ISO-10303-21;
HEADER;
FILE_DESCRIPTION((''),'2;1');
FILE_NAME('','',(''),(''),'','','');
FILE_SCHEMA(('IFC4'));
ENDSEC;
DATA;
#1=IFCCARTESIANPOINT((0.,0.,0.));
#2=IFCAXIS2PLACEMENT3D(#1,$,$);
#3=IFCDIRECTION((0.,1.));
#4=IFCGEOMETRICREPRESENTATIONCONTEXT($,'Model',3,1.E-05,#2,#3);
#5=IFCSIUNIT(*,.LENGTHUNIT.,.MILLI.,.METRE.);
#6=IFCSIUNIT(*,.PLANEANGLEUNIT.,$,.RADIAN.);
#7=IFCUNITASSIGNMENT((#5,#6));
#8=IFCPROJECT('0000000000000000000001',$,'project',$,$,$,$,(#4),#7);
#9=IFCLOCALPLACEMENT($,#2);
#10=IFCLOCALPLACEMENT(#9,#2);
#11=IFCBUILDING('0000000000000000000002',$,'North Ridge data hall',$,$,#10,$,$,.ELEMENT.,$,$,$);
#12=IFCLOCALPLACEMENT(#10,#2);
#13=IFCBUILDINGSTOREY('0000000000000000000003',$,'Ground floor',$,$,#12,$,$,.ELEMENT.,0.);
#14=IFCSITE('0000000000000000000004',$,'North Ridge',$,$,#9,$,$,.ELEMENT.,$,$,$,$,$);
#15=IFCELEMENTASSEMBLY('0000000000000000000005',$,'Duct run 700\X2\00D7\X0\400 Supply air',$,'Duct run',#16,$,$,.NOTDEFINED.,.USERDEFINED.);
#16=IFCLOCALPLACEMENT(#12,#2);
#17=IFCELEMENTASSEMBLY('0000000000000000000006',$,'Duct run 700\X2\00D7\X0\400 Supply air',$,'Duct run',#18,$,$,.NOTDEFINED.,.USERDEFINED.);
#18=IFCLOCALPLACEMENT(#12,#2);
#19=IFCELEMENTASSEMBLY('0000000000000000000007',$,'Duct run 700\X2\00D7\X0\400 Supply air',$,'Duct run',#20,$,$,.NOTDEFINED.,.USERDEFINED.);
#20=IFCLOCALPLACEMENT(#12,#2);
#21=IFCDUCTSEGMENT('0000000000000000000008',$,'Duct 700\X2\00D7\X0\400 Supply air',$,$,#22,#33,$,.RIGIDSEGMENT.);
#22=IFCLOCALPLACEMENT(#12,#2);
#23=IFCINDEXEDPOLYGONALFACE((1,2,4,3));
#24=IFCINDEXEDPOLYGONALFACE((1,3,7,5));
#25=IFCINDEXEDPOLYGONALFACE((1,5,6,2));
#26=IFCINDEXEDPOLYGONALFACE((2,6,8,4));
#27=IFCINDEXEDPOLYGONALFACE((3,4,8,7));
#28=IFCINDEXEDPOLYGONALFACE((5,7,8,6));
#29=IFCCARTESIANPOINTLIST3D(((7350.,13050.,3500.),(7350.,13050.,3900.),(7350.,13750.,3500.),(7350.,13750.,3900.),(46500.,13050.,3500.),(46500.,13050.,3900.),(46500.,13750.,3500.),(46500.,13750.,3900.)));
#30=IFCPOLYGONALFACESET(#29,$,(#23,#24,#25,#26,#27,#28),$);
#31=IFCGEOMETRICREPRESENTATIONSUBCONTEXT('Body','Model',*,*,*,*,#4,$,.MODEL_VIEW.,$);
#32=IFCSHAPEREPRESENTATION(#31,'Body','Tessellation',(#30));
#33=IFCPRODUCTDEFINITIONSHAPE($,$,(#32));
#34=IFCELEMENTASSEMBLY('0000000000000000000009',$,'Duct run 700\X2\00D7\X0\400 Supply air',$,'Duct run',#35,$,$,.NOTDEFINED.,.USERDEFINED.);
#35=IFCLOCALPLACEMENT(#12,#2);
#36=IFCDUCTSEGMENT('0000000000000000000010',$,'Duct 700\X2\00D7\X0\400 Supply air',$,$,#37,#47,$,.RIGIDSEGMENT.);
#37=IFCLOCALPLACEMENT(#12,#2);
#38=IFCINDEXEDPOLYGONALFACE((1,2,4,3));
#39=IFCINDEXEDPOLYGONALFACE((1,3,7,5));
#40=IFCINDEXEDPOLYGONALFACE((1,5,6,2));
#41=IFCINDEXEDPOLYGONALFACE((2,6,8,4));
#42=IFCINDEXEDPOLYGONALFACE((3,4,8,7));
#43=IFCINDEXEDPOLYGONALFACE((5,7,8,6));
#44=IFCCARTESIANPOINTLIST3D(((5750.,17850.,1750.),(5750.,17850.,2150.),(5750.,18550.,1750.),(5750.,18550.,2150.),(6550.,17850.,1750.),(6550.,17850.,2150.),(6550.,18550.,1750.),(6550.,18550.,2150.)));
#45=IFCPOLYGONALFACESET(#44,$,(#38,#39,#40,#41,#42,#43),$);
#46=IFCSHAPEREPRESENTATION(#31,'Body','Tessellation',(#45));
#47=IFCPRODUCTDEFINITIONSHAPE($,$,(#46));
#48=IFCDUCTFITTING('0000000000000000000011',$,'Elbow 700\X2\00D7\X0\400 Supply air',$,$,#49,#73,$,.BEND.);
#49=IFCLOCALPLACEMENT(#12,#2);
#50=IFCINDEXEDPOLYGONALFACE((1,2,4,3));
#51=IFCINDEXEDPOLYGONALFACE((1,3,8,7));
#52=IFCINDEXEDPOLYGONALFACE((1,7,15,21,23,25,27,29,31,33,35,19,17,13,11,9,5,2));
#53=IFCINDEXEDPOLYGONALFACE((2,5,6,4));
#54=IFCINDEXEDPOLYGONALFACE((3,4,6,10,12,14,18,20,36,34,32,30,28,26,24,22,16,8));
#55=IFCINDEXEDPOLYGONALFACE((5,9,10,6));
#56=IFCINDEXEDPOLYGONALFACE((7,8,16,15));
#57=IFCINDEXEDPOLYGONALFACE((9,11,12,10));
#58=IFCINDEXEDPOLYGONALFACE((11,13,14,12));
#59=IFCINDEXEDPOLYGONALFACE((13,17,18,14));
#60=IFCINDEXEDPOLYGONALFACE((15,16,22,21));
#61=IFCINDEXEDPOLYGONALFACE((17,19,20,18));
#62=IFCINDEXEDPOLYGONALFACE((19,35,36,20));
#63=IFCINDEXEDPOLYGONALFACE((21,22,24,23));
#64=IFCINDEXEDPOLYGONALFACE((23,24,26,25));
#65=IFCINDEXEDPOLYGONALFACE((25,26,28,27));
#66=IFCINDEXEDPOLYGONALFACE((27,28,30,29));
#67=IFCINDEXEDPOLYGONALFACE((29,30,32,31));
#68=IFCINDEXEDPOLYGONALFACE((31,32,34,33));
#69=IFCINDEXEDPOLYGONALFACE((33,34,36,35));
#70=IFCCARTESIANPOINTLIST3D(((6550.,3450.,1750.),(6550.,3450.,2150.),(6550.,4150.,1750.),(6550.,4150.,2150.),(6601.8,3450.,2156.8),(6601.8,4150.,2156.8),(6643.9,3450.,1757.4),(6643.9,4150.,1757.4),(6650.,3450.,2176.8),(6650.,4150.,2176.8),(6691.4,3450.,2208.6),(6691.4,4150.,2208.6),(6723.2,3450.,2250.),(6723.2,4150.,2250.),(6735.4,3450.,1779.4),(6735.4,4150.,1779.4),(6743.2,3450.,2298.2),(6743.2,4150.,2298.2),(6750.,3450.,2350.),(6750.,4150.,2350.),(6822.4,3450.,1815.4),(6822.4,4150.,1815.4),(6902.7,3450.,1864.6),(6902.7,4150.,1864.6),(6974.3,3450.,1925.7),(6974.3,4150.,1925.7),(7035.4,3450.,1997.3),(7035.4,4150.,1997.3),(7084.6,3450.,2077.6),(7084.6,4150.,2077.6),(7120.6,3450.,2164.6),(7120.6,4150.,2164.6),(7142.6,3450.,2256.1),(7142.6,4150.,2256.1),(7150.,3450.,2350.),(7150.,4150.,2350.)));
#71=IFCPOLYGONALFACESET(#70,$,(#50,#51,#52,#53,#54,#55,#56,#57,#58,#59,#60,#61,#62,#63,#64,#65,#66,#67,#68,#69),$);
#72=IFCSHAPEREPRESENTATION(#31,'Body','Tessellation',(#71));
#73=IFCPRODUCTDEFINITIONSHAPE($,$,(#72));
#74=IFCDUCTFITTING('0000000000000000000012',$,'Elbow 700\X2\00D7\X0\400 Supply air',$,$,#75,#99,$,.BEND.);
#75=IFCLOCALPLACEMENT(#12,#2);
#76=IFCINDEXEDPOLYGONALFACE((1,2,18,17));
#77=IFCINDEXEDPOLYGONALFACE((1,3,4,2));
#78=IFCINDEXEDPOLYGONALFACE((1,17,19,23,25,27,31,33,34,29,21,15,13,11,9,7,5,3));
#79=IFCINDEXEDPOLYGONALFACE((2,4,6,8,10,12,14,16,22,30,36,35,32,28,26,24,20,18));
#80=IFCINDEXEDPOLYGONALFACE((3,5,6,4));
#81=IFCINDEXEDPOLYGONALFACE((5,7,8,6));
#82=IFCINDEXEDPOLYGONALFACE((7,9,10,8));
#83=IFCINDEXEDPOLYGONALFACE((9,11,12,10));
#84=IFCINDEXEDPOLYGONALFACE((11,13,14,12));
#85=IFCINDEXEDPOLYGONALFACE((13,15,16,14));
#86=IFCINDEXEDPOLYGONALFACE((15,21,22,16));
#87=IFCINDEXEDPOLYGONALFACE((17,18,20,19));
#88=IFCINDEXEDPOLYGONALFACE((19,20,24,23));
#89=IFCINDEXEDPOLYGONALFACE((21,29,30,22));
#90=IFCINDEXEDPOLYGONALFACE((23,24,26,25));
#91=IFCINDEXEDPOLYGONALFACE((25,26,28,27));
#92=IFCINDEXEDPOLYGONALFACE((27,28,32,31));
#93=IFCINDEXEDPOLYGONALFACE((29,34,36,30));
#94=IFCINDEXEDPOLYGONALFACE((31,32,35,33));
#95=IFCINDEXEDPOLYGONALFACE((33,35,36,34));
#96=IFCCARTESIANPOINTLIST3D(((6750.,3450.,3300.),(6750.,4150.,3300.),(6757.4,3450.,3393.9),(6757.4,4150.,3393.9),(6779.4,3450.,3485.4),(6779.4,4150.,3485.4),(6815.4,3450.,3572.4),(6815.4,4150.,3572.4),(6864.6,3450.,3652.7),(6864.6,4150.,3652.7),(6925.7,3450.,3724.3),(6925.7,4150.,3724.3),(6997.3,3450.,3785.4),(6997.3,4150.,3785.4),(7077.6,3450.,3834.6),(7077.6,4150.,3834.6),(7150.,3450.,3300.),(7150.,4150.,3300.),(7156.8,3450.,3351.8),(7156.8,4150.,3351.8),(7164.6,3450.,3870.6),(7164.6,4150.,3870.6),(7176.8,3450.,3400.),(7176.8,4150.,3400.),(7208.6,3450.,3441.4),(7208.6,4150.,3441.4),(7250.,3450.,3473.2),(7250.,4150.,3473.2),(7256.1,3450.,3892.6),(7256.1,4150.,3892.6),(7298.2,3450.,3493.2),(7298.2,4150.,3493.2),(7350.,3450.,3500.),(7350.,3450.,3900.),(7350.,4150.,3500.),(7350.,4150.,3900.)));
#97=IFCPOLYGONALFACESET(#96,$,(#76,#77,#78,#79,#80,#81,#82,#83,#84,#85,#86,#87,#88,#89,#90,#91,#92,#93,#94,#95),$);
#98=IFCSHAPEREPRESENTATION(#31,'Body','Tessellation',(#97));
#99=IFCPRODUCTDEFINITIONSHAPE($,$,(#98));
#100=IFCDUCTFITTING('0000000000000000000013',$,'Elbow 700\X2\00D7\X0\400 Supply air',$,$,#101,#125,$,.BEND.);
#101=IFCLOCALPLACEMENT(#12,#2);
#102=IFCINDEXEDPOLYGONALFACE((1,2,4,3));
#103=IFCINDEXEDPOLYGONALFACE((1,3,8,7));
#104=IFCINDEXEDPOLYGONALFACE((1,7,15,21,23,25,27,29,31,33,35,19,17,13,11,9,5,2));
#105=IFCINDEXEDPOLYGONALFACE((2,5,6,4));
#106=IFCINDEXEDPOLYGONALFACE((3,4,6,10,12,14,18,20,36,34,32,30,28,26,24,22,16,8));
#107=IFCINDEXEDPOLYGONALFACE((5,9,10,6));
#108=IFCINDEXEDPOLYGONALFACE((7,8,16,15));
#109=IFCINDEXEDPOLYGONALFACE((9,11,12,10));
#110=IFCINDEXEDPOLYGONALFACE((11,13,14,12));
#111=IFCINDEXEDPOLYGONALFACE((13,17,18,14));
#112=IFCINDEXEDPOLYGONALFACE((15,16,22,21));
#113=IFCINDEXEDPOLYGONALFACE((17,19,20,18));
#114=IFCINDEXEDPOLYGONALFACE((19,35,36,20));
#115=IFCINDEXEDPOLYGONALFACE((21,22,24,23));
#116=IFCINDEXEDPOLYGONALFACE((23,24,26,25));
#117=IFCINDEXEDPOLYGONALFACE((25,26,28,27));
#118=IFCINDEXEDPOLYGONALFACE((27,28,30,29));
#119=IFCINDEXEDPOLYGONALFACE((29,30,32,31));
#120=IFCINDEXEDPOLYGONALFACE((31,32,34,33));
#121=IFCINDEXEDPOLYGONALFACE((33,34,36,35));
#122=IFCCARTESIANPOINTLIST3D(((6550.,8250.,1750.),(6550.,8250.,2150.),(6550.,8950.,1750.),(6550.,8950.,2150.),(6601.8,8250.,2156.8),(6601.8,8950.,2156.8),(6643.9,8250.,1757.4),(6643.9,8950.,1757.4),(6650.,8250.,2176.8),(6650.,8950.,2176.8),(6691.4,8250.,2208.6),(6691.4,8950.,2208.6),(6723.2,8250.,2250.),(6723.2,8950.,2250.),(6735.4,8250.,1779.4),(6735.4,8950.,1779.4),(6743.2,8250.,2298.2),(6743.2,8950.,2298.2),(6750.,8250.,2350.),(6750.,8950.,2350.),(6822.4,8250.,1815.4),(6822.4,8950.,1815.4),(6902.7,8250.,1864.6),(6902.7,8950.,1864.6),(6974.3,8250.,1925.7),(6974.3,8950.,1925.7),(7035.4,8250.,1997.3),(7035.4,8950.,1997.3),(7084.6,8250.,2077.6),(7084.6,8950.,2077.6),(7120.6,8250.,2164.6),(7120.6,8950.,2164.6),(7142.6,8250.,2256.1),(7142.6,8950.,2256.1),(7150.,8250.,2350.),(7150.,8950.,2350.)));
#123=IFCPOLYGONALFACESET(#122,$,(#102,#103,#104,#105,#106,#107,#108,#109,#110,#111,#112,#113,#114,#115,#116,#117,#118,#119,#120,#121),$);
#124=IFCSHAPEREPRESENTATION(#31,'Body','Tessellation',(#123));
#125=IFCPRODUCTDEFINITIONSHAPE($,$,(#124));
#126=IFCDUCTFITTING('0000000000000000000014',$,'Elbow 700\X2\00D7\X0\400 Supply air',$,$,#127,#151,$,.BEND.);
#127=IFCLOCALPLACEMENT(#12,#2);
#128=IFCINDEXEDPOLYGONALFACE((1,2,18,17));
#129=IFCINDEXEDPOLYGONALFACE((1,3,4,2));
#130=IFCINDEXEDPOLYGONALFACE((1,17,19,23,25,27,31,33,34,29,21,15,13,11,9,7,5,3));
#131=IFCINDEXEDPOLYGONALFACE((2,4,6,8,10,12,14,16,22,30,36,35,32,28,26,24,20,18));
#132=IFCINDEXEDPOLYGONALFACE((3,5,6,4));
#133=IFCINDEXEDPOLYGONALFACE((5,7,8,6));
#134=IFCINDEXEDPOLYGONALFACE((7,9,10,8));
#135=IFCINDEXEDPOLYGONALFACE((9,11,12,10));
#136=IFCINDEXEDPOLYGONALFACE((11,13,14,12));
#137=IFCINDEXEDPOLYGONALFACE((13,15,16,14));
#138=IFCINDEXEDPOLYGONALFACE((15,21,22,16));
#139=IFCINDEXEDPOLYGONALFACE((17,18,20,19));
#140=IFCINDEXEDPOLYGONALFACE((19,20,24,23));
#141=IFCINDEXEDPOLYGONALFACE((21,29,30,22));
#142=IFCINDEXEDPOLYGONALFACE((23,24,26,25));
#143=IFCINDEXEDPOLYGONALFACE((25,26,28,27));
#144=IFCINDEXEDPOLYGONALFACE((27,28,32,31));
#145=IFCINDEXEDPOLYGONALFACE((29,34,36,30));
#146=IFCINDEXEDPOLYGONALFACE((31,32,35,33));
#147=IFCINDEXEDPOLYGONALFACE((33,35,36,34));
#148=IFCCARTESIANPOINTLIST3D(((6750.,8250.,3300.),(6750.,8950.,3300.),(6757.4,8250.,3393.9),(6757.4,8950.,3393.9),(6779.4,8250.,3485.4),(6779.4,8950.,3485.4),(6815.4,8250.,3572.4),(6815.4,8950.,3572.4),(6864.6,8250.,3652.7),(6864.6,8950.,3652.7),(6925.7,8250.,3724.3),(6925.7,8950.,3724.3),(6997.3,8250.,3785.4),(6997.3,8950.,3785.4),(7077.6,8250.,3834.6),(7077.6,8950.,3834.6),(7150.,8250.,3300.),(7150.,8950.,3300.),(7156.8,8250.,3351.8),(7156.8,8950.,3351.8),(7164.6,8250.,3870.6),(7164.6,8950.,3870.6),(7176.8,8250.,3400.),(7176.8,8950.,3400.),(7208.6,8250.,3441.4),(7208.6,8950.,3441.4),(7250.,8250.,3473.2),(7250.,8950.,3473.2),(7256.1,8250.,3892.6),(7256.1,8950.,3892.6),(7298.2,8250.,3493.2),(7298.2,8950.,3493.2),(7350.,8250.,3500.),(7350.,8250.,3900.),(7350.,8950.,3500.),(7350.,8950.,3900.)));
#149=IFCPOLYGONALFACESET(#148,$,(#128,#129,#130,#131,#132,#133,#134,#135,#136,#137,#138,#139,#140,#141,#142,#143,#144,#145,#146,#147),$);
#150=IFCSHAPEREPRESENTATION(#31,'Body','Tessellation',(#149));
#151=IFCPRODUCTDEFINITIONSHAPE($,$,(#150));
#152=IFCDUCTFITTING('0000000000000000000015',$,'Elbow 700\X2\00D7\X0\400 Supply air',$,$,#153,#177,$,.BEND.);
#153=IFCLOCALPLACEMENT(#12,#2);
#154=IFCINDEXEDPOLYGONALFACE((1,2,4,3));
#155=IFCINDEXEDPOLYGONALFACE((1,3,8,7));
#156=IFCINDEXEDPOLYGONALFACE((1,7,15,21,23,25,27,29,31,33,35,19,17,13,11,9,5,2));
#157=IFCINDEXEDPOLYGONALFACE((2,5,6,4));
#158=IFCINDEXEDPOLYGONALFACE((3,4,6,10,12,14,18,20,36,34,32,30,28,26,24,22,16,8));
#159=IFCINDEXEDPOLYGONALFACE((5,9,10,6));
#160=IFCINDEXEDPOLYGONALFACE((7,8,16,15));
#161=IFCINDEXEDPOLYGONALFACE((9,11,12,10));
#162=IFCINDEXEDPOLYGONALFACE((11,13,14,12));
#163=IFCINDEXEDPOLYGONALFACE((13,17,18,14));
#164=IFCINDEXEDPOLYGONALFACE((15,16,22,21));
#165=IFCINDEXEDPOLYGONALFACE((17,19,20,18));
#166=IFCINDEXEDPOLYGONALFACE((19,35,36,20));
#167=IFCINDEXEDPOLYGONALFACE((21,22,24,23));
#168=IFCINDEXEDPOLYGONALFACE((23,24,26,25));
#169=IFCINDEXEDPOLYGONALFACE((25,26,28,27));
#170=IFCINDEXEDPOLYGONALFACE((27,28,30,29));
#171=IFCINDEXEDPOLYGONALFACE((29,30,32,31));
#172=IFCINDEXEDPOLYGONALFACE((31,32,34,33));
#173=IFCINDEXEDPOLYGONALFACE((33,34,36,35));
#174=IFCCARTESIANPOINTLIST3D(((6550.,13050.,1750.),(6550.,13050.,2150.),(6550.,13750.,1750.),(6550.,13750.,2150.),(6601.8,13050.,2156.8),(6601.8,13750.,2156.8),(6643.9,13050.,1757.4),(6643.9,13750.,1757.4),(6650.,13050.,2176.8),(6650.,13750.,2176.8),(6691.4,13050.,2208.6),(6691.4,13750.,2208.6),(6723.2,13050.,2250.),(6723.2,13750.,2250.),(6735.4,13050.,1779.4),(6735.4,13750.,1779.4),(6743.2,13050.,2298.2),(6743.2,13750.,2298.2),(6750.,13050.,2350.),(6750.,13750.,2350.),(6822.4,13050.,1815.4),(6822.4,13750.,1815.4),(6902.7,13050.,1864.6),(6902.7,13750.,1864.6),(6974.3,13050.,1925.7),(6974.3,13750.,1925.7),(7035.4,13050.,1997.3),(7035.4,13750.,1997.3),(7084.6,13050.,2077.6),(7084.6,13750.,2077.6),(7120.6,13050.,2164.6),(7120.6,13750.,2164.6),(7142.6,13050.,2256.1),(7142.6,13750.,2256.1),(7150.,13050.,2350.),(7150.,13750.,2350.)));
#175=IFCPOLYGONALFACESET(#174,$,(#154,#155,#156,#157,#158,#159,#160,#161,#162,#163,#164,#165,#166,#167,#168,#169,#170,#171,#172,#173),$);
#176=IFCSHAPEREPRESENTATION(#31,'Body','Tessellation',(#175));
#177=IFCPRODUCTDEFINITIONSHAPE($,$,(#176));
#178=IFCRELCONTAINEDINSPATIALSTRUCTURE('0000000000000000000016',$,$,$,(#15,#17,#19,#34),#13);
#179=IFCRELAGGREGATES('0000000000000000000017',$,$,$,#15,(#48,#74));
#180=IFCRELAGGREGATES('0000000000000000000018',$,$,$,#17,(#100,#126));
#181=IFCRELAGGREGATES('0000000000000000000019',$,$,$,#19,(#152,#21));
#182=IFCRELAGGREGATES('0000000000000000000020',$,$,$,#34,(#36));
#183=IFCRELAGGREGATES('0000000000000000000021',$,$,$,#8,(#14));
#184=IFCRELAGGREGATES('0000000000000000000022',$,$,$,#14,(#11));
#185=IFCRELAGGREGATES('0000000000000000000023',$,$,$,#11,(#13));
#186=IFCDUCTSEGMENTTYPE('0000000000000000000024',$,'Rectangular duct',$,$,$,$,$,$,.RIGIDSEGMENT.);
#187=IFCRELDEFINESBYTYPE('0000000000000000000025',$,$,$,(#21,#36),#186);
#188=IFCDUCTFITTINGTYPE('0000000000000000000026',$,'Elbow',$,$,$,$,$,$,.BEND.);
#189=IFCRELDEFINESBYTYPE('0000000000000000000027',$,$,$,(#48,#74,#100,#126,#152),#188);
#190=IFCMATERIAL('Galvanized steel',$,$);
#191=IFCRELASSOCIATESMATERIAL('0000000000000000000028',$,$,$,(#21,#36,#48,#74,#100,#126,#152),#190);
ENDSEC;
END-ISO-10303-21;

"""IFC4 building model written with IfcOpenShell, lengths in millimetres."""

from ifc_helpers import new_model, entity, si_unit, direction, frame, origin, origin_with_axes, origin_2d, place, context, subcontext, project, spatial, rectangle, extrude, material, type_object, element, aggregate, save


model = new_model("IFC4")

# Units and contexts
model_context = context("Model", 3, precision=1e-05, world=origin(), true_north=direction((0.0, 1.0)))
body_context = subcontext(model_context, "Body", "Model", "MODEL_VIEW")
ifc_project = project(units=[si_unit("LENGTHUNIT", "METRE", prefix="MILLI"), si_unit("PLANEANGLEUNIT", "RADIAN")], contexts=[model_context])

# Site, building, storey
site_placement = place(None, origin())
site = spatial("IfcSite", under=ifc_project, at=site_placement, Name="North Ridge", CompositionType="ELEMENT")
building_placement = place(site_placement, origin())
building = spatial("IfcBuilding", under=site, at=building_placement, Name="North Ridge data hall", CompositionType="ELEMENT")
storey_placement = place(building_placement, origin())
storey = spatial("IfcBuildingStorey", under=building, at=storey_placement, Name="Ground floor", CompositionType="ELEMENT", Elevation=0.0)

# Element assemblies, duct segment
assembly_1_placement = place(storey_placement, origin_with_axes())
assembly_1 = element("IfcElementAssembly", 1, at=assembly_1_placement, inside=storey, Name="Duct run 700×400 Supply air", ObjectType="Duct run", AssemblyPlace="NOTDEFINED", PredefinedType="USERDEFINED")
ifc_material_1 = material(Name="Galvanized steel")
duct_segment_type = type_object("IfcDuctSegmentType", Name="Rectangular duct", PredefinedType="RIGIDSEGMENT")
assembly_2_placement = place(storey_placement, origin_with_axes())
assembly_2 = element("IfcElementAssembly", 2, at=assembly_2_placement, inside=storey, Name="Duct run 700×400 Supply air", ObjectType="Duct run", AssemblyPlace="NOTDEFINED", PredefinedType="USERDEFINED")
assembly_3_placement = place(storey_placement, origin_with_axes())
assembly_3 = element("IfcElementAssembly", 3, at=assembly_3_placement, inside=storey, Name="Duct run 700×400 Supply air", ObjectType="Duct run", AssemblyPlace="NOTDEFINED", PredefinedType="USERDEFINED")
duct_segment_1_placement = place(storey_placement, origin_with_axes())
duct_segment_1 = element("IfcDuctSegment", 4, at=duct_segment_1_placement, type_object=duct_segment_type, material=ifc_material_1, Name="Duct 700×400 Supply air", PredefinedType="RIGIDSEGMENT", context=body_context, shape_type="SweptSolid", body=[
    extrude(rectangle(XDim=700.0, YDim=400.0, at=origin_2d()), frame((7350.0, 13400.0, 3700.0), z_axis=(1.0, 0.0, 0.0), x_axis=(0.0, 1.0, 0.0)), (0.0, 0.0, 1.0), 39150.0),
])

# Element assembly, duct segment
assembly_4_placement = place(storey_placement, origin_with_axes())
assembly_4 = element("IfcElementAssembly", 5, at=assembly_4_placement, inside=storey, Name="Duct run 700×400 Supply air", ObjectType="Duct run", AssemblyPlace="NOTDEFINED", PredefinedType="USERDEFINED")
duct_segment_2_placement = place(storey_placement, origin_with_axes())
duct_segment_2 = element("IfcDuctSegment", 6, at=duct_segment_2_placement, type_object=duct_segment_type, material=ifc_material_1, Name="Duct 700×400 Supply air", PredefinedType="RIGIDSEGMENT", context=body_context, shape_type="SweptSolid", body=[
    extrude(rectangle(XDim=700.0, YDim=400.0, at=origin_2d()), frame((5750.0, 18200.0, 1950.0), z_axis=(1.0, 0.0, 0.0), x_axis=(0.0, 1.0, 0.0)), (0.0, 0.0, 1.0), 800.0),
])

# Duct fittings
duct_fitting_type = type_object("IfcDuctFittingType", Name="Elbow", PredefinedType="BEND")
duct_fitting_1_placement = place(storey_placement, origin_with_axes())
duct_fitting_1 = element("IfcDuctFitting", 7, at=duct_fitting_1_placement, type_object=duct_fitting_type, material=ifc_material_1, Name="Elbow 700×400 Supply air", PredefinedType="BEND", context=body_context, shape_type="SweptSolid", body=[
    entity("IfcRevolvedAreaSolid", entity("IfcRectangleProfileDef", "AREA", None, entity("IfcAxis2Placement2D", entity("IfcCartesianPoint", [0.0, 0.0])), 700.0, 400.0), entity("IfcAxis2Placement3D", entity("IfcCartesianPoint", [6550.0, 3800.0, 1950.0]), entity("IfcDirection", [1.0, 0.0, 0.0]), entity("IfcDirection", [0.0, 1.0, 0.0])), entity("IfcAxis1Placement", entity("IfcCartesianPoint", [0.0, 400.0, 0.0]), entity("IfcDirection", [-1.0, 0.0, 0.0])), 1.570796),
])
duct_fitting_2_placement = place(storey_placement, origin_with_axes())
duct_fitting_2 = element("IfcDuctFitting", 8, at=duct_fitting_2_placement, type_object=duct_fitting_type, material=ifc_material_1, Name="Elbow 700×400 Supply air", PredefinedType="BEND", context=body_context, shape_type="SweptSolid", body=[
    entity("IfcRevolvedAreaSolid", entity("IfcRectangleProfileDef", "AREA", None, entity("IfcAxis2Placement2D", entity("IfcCartesianPoint", [0.0, 0.0])), 700.0, 400.0), entity("IfcAxis2Placement3D", entity("IfcCartesianPoint", [6950.0, 3800.0, 3300.0]), entity("IfcDirection", [0.0, 0.0, 1.0]), entity("IfcDirection", [0.0, 1.0, 0.0])), entity("IfcAxis1Placement", entity("IfcCartesianPoint", [0.0, -400.0, 0.0]), entity("IfcDirection", [1.0, 0.0, 0.0])), 1.570796),
])
aggregate(assembly_1, [duct_fitting_1, duct_fitting_2])
duct_fitting_3_placement = place(storey_placement, origin_with_axes())
duct_fitting_3 = element("IfcDuctFitting", 9, at=duct_fitting_3_placement, type_object=duct_fitting_type, material=ifc_material_1, Name="Elbow 700×400 Supply air", PredefinedType="BEND", context=body_context, shape_type="SweptSolid", body=[
    entity("IfcRevolvedAreaSolid", entity("IfcRectangleProfileDef", "AREA", None, entity("IfcAxis2Placement2D", entity("IfcCartesianPoint", [0.0, 0.0])), 700.0, 400.0), entity("IfcAxis2Placement3D", entity("IfcCartesianPoint", [6550.0, 8600.0, 1950.0]), entity("IfcDirection", [1.0, 0.0, 0.0]), entity("IfcDirection", [0.0, 1.0, 0.0])), entity("IfcAxis1Placement", entity("IfcCartesianPoint", [0.0, 400.0, 0.0]), entity("IfcDirection", [-1.0, 0.0, 0.0])), 1.570796),
])
duct_fitting_4_placement = place(storey_placement, origin_with_axes())
duct_fitting_4 = element("IfcDuctFitting", 10, at=duct_fitting_4_placement, type_object=duct_fitting_type, material=ifc_material_1, Name="Elbow 700×400 Supply air", PredefinedType="BEND", context=body_context, shape_type="SweptSolid", body=[
    entity("IfcRevolvedAreaSolid", entity("IfcRectangleProfileDef", "AREA", None, entity("IfcAxis2Placement2D", entity("IfcCartesianPoint", [0.0, 0.0])), 700.0, 400.0), entity("IfcAxis2Placement3D", entity("IfcCartesianPoint", [6950.0, 8600.0, 3300.0]), entity("IfcDirection", [0.0, 0.0, 1.0]), entity("IfcDirection", [0.0, 1.0, 0.0])), entity("IfcAxis1Placement", entity("IfcCartesianPoint", [0.0, -400.0, 0.0]), entity("IfcDirection", [1.0, 0.0, 0.0])), 1.570796),
])
aggregate(assembly_2, [duct_fitting_3, duct_fitting_4])
duct_fitting_5_placement = place(storey_placement, origin_with_axes())
duct_fitting_5 = element("IfcDuctFitting", 11, at=duct_fitting_5_placement, type_object=duct_fitting_type, material=ifc_material_1, Name="Elbow 700×400 Supply air", PredefinedType="BEND", context=body_context, shape_type="SweptSolid", body=[
    entity("IfcRevolvedAreaSolid", entity("IfcRectangleProfileDef", "AREA", None, entity("IfcAxis2Placement2D", entity("IfcCartesianPoint", [0.0, 0.0])), 700.0, 400.0), entity("IfcAxis2Placement3D", entity("IfcCartesianPoint", [6550.0, 13400.0, 1950.0]), entity("IfcDirection", [1.0, 0.0, 0.0]), entity("IfcDirection", [0.0, 1.0, 0.0])), entity("IfcAxis1Placement", entity("IfcCartesianPoint", [0.0, 400.0, 0.0]), entity("IfcDirection", [-1.0, 0.0, 0.0])), 1.570796),
])
aggregate(assembly_3, [duct_fitting_5, duct_segment_1])
aggregate(assembly_4, [duct_segment_2])

save(model, "model.ifc")
